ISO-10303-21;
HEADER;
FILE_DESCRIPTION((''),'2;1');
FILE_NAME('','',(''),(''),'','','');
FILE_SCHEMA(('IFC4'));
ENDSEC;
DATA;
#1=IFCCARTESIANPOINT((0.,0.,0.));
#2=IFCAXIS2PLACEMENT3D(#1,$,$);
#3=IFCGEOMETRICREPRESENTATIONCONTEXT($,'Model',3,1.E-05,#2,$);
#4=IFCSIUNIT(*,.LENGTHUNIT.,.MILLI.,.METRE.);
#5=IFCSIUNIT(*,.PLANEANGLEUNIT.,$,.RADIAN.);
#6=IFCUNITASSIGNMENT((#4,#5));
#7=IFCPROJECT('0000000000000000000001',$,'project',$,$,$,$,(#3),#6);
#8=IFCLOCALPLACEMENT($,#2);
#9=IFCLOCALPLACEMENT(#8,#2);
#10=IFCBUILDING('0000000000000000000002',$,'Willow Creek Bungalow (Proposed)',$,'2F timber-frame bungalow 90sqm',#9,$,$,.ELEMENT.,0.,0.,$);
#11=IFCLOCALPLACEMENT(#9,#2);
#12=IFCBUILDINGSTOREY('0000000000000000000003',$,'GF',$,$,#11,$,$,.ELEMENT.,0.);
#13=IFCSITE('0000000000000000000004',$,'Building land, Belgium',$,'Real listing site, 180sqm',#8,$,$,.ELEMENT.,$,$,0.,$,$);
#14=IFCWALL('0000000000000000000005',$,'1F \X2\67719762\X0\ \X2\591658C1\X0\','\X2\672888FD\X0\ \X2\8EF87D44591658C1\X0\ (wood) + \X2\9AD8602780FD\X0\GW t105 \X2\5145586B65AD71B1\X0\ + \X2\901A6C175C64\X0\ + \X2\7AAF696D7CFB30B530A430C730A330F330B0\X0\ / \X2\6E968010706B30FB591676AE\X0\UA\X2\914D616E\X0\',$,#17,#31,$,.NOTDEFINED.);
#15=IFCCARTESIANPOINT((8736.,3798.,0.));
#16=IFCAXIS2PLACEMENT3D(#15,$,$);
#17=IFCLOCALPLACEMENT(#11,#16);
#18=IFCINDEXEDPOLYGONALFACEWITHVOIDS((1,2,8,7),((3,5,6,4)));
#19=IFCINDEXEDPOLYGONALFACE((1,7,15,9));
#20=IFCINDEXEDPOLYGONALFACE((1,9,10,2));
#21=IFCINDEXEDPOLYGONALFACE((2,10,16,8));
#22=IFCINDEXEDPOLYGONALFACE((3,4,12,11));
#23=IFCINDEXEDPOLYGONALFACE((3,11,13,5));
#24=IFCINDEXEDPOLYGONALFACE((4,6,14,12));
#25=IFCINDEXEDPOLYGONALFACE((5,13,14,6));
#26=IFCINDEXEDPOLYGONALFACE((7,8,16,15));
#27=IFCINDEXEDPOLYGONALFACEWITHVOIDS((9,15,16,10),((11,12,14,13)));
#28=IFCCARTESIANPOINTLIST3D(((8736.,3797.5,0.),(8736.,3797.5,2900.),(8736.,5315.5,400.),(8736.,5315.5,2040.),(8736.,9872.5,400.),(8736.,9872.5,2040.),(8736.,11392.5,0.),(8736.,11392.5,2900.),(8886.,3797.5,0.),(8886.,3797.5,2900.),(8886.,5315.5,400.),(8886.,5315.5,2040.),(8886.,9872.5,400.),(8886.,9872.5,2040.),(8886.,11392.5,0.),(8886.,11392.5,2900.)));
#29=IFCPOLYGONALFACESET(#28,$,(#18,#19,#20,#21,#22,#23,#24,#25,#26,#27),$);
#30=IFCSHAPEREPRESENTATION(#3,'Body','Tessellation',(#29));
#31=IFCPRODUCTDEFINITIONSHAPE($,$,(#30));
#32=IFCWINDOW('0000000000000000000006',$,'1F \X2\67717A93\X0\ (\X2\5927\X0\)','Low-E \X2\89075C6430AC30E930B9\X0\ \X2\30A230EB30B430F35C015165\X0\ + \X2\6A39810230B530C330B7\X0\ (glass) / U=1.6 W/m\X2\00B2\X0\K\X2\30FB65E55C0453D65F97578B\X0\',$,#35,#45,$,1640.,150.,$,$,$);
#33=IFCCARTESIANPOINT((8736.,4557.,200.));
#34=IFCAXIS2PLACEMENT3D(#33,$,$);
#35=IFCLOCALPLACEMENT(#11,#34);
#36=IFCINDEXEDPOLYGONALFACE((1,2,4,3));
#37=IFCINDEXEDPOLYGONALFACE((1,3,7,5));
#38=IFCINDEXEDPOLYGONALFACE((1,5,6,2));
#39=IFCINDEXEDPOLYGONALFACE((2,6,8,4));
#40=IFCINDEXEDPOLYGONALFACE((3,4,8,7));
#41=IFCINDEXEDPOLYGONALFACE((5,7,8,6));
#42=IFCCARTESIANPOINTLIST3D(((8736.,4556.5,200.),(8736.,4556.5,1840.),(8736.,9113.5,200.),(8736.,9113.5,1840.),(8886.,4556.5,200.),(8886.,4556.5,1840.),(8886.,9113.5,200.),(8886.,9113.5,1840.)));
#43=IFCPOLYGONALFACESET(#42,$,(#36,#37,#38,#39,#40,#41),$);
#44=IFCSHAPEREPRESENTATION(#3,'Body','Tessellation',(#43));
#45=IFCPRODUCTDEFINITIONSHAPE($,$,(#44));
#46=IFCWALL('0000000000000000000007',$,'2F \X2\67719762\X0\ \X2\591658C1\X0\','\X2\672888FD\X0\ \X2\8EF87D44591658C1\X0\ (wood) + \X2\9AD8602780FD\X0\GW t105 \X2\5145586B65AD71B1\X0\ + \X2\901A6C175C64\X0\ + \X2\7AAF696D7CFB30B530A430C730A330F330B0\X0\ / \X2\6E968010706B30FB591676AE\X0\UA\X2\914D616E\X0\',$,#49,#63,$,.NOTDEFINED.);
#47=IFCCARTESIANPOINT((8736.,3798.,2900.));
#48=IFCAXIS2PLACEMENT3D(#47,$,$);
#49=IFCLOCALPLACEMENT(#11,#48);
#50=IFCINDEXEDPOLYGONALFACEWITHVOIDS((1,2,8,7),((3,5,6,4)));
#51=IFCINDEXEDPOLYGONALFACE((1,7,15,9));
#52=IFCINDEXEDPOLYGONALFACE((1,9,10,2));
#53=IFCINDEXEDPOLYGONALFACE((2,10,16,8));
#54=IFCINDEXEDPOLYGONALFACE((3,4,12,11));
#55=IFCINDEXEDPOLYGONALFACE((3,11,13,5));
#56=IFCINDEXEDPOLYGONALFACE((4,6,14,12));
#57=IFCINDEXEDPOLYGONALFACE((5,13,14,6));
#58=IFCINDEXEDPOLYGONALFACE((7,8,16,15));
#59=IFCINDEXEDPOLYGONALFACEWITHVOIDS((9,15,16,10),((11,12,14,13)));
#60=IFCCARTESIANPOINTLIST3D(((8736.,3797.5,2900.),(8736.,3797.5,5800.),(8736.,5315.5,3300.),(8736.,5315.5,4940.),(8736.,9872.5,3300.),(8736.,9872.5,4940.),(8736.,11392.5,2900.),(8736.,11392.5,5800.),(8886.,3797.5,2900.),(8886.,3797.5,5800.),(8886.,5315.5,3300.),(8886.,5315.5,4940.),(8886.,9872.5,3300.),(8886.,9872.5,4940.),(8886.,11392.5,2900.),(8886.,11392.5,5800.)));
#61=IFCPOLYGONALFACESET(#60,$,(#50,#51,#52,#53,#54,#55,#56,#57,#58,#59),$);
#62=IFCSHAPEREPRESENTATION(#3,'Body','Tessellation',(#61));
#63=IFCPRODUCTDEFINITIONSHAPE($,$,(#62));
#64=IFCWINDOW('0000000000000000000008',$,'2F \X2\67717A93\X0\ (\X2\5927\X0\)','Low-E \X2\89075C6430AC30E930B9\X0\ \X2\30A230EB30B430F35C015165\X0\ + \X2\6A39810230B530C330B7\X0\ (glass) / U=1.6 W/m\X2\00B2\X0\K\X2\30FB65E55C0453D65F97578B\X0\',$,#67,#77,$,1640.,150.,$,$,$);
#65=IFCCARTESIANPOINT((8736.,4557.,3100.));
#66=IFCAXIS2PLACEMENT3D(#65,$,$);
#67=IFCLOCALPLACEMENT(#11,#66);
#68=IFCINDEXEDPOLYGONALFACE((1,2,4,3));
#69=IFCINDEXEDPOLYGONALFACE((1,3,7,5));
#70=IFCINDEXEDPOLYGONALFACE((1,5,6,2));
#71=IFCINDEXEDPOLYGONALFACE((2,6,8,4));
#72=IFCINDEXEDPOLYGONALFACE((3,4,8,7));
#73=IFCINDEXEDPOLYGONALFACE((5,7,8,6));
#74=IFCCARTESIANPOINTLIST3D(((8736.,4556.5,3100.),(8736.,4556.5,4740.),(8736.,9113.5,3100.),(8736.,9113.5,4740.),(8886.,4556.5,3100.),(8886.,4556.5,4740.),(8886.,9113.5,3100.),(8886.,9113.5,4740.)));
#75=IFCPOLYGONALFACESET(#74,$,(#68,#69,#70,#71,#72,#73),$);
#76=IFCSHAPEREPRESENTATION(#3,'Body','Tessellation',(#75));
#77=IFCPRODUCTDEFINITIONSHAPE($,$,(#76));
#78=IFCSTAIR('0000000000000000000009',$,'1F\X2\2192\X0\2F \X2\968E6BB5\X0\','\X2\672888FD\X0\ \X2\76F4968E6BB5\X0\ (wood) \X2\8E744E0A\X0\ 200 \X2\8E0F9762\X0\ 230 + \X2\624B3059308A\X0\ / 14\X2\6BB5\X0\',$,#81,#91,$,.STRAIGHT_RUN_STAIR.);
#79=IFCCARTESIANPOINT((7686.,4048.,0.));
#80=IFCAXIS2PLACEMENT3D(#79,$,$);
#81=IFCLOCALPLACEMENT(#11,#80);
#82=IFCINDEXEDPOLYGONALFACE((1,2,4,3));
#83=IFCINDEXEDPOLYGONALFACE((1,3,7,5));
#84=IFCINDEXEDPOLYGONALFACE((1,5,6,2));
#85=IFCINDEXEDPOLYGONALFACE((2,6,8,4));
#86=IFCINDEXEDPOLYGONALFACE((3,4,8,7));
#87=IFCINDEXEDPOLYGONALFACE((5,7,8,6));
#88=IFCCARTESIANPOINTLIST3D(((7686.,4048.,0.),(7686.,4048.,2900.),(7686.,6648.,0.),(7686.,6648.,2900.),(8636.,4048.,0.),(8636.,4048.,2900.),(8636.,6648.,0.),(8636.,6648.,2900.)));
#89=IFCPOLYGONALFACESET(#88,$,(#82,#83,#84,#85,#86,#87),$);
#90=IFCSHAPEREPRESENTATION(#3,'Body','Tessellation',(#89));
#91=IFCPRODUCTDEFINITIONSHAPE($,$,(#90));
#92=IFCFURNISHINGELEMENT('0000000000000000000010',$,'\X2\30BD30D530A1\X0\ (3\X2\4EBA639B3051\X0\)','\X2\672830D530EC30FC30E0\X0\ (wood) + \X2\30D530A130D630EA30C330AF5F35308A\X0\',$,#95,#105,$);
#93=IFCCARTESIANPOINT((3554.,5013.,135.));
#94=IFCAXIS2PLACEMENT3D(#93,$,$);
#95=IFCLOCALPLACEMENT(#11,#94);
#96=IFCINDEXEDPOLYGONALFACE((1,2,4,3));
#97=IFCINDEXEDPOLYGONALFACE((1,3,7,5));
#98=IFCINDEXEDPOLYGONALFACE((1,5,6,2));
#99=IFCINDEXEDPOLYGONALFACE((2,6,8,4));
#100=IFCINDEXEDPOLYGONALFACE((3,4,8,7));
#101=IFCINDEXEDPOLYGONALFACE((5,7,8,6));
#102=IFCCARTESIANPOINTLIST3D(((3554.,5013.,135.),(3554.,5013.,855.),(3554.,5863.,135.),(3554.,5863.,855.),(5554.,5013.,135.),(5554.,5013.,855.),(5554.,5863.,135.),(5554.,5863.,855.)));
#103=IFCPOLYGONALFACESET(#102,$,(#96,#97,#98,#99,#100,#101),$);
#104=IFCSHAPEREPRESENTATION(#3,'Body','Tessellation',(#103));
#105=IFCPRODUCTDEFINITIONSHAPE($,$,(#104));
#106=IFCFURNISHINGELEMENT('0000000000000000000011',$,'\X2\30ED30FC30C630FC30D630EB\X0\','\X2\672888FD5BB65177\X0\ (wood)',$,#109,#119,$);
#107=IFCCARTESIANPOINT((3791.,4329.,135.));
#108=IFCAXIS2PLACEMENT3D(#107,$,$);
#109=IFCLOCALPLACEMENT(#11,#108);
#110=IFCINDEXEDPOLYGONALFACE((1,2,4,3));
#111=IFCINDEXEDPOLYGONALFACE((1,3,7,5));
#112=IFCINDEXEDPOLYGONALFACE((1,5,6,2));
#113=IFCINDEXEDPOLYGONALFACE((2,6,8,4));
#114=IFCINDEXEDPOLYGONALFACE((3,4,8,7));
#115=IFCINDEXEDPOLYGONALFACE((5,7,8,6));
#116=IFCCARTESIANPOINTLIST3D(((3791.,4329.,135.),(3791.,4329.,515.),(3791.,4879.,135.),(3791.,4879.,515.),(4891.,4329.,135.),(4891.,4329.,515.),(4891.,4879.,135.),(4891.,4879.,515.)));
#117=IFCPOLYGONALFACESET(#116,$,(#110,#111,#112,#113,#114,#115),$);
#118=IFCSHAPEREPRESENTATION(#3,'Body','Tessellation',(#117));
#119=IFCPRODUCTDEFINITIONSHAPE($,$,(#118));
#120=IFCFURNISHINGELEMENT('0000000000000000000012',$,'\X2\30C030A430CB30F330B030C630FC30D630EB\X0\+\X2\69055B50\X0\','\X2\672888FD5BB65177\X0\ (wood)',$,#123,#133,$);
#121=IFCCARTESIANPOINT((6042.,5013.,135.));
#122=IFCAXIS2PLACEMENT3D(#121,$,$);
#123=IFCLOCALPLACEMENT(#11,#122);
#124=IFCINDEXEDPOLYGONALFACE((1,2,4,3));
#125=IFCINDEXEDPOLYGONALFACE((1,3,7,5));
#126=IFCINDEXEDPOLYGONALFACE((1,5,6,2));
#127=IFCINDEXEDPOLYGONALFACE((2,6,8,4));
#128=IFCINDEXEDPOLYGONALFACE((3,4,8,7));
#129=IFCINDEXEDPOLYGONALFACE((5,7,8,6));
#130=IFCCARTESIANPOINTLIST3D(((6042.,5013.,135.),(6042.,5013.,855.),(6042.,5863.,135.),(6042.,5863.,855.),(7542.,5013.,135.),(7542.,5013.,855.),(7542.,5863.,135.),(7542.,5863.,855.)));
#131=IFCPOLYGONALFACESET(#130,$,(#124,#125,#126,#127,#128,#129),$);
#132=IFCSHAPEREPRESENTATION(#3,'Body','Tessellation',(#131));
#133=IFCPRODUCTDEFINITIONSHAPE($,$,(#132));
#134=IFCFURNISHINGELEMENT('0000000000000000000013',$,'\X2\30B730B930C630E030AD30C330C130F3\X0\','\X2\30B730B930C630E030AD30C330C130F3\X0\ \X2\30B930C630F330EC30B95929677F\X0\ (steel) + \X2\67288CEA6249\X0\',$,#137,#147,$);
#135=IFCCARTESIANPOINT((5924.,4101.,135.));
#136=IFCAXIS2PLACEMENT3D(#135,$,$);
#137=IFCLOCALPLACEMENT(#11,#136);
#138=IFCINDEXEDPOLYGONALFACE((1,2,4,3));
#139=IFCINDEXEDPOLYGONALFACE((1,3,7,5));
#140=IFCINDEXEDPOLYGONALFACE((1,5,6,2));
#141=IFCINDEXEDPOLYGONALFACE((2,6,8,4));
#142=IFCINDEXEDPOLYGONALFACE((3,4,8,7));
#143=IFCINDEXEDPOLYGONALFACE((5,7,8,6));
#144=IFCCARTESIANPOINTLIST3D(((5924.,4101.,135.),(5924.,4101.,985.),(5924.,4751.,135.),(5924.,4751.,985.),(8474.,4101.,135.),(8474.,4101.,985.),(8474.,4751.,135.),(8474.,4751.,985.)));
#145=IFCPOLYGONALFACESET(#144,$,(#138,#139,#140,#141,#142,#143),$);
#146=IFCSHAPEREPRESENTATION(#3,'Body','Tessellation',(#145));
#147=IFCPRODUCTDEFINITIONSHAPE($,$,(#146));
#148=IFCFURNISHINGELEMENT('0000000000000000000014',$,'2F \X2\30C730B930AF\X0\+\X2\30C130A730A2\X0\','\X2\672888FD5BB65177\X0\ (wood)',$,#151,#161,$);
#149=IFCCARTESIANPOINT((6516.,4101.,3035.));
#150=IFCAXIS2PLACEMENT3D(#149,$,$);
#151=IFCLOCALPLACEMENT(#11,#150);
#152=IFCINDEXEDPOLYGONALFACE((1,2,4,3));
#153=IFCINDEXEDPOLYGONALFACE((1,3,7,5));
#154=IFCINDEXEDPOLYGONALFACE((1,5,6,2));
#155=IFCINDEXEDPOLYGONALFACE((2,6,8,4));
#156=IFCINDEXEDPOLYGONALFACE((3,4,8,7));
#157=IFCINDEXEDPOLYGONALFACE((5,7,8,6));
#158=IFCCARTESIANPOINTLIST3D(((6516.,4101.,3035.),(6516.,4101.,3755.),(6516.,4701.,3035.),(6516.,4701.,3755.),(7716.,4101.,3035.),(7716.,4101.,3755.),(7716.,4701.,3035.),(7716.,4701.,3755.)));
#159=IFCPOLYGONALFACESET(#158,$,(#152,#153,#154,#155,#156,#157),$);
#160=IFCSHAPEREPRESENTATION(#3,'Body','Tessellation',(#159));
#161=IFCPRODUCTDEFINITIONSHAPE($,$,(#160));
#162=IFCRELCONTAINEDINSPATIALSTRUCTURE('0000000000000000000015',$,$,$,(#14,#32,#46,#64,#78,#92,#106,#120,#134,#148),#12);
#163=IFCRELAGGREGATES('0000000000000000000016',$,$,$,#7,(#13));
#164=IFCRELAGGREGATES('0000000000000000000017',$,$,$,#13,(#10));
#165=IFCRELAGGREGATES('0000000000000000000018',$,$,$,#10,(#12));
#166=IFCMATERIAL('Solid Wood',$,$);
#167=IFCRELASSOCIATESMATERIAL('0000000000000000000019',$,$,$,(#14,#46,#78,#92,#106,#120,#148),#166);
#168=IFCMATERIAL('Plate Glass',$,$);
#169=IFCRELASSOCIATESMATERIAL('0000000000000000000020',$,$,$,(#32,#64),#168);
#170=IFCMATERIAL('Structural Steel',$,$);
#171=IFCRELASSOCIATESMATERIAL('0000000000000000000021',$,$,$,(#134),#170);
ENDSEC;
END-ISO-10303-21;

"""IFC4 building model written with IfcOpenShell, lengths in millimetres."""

from ifc_helpers import new_model, si_unit, frame, frame_2d, origin, place, context, project, spatial, rectangle, extrude, material, element, fill, save


model = new_model("IFC4")

# Units and contexts
model_context = context("Model", 3, precision=1e-05, world=origin())
ifc_project = project(units=[si_unit("LENGTHUNIT", "METRE", prefix="MILLI"), si_unit("PLANEANGLEUNIT", "RADIAN")], contexts=[model_context])

# Site, building, storey
site_placement = place(None, origin())
site = spatial("IfcSite", under=ifc_project, at=site_placement, Name="Building land, Belgium", ObjectType="Real listing site, 180sqm", CompositionType="ELEMENT", RefElevation=0.0)
building_placement = place(site_placement, origin())
building = spatial("IfcBuilding", under=site, at=building_placement, Name="Willow Creek Bungalow (Proposed)", ObjectType="2F timber-frame bungalow 90sqm", CompositionType="ELEMENT", ElevationOfRefHeight=0.0, ElevationOfTerrain=0.0)
storey_placement = place(building_placement, origin())
storey = spatial("IfcBuildingStorey", under=building, at=storey_placement, Name="GF", CompositionType="ELEMENT", Elevation=0.0)

# Wall, opening, window
ifc_material_1 = material(Name="Solid Wood")
wall_1_placement = place(storey_placement, frame((8736.0, 3798.0, 0.0)))
wall_1 = element("IfcWall", 1, at=wall_1_placement, inside=storey, material=ifc_material_1, Name="1F 東面 外壁", Description="木製 軸組外壁 (wood) + 高性能GW t105 充填断熱 + 通気層 + 窯業系サイディング / 準耐火・外皮UA配慮", PredefinedType="NOTDEFINED", context=model_context, shape_type="SweptSolid", body=[
    extrude(rectangle(XDim=150.0, YDim=7595.0, at=frame_2d((75.0, 3797.0))), frame((8736.0, 3798.0, 0.0)), (0.0, 0.0, 1.0), 2900.0),
])
opening_1_placement = place(storey_placement, frame((8736.0, 4557.0, 200.0)))
opening_1 = element("IfcOpeningElement", 2, at=opening_1_placement, cuts=wall_1, PredefinedType="NOTDEFINED", context=model_context, shape_type="SweptSolid", body=[
    extrude(rectangle(XDim=150.0, YDim=4557.0, at=frame_2d((75.0, 2278.0))), frame((8736.0, 4557.0, 200.0)), (0.0, 0.0, 1.0), 1640.0),
])
ifc_material_2 = material(Name="Plate Glass")
window_1_placement = place(storey_placement, frame((8736.0, 4557.0, 200.0)))
window_1 = element("IfcWindow", 3, at=window_1_placement, inside=storey, material=ifc_material_2, Name="1F 東窓 (大)", Description="Low-E 複層ガラス アルゴン封入 + 樹脂サッシ (glass) / U=1.6 W/m²K・日射取得型", OverallHeight=1640.0, OverallWidth=150.0, context=model_context, shape_type="SweptSolid", body=[
    extrude(rectangle(XDim=150.0, YDim=4557.0, at=frame_2d((75.0, 2278.0))), frame((8736.0, 4557.0, 200.0)), (0.0, 0.0, 1.0), 1640.0),
])
fill(opening_1, window_1)

# Wall, opening, window
wall_2_placement = place(storey_placement, frame((8736.0, 3798.0, 2900.0)))
wall_2 = element("IfcWall", 4, at=wall_2_placement, inside=storey, material=ifc_material_1, Name="2F 東面 外壁", Description="木製 軸組外壁 (wood) + 高性能GW t105 充填断熱 + 通気層 + 窯業系サイディング / 準耐火・外皮UA配慮", PredefinedType="NOTDEFINED", context=model_context, shape_type="SweptSolid", body=[
    extrude(rectangle(XDim=150.0, YDim=7595.0, at=frame_2d((75.0, 3797.0))), frame((8736.0, 3798.0, 2900.0)), (0.0, 0.0, 1.0), 2900.0),
])
opening_2_placement = place(storey_placement, frame((8736.0, 4557.0, 3100.0)))
opening_2 = element("IfcOpeningElement", 5, at=opening_2_placement, cuts=wall_2, PredefinedType="NOTDEFINED", context=model_context, shape_type="SweptSolid", body=[
    extrude(rectangle(XDim=150.0, YDim=4557.0, at=frame_2d((75.0, 2278.0))), frame((8736.0, 4557.0, 3100.0)), (0.0, 0.0, 1.0), 1640.0),
])
window_2_placement = place(storey_placement, frame((8736.0, 4557.0, 3100.0)))
window_2 = element("IfcWindow", 6, at=window_2_placement, inside=storey, material=ifc_material_2, Name="2F 東窓 (大)", Description="Low-E 複層ガラス アルゴン封入 + 樹脂サッシ (glass) / U=1.6 W/m²K・日射取得型", OverallHeight=1640.0, OverallWidth=150.0, context=model_context, shape_type="SweptSolid", body=[
    extrude(rectangle(XDim=150.0, YDim=4557.0, at=frame_2d((75.0, 2278.0))), frame((8736.0, 4557.0, 3100.0)), (0.0, 0.0, 1.0), 1640.0),
])
fill(opening_2, window_2)

# Stair
stair_placement = place(storey_placement, frame((7686.0, 4048.0, 0.0)))
element("IfcStair", 7, at=stair_placement, inside=storey, material=ifc_material_1, Name="1F→2F 階段", Description="木製 直階段 (wood) 蹴上 200 踏面 230 + 手すり / 14段", PredefinedType="STRAIGHT_RUN_STAIR", context=model_context, shape_type="SweptSolid", body=[
    extrude(rectangle(XDim=950.0, YDim=2600.0, at=frame_2d((475.0, 1300.0))), frame((7686.0, 4048.0, 0.0)), (0.0, 0.0, 1.0), 2900.0),
])

# Furnishing elements
furnishing_1_placement = place(storey_placement, frame((3554.0, 5013.0, 135.0)))
element("IfcFurnishingElement", 8, at=furnishing_1_placement, inside=storey, material=ifc_material_1, Name="ソファ (3人掛け)", Description="木フレーム (wood) + ファブリック張り", context=model_context, shape_type="SweptSolid", body=[
    extrude(rectangle(XDim=2000.0, YDim=850.0, at=frame_2d((1000.0, 425.0))), frame((3554.0, 5013.0, 135.0)), (0.0, 0.0, 1.0), 720.0),
])
furnishing_2_placement = place(storey_placement, frame((3791.0, 4329.0, 135.0)))
element("IfcFurnishingElement", 9, at=furnishing_2_placement, inside=storey, material=ifc_material_1, Name="ローテーブル", Description="木製家具 (wood)", context=model_context, shape_type="SweptSolid", body=[
    extrude(rectangle(XDim=1100.0, YDim=550.0, at=frame_2d((550.0, 275.0))), frame((3791.0, 4329.0, 135.0)), (0.0, 0.0, 1.0), 380.0),
])
furnishing_3_placement = place(storey_placement, frame((6042.0, 5013.0, 135.0)))
element("IfcFurnishingElement", 10, at=furnishing_3_placement, inside=storey, material=ifc_material_1, Name="ダイニングテーブル+椅子", Description="木製家具 (wood)", context=model_context, shape_type="SweptSolid", body=[
    extrude(rectangle(XDim=1500.0, YDim=850.0, at=frame_2d((750.0, 425.0))), frame((6042.0, 5013.0, 135.0)), (0.0, 0.0, 1.0), 720.0),
])
ifc_material_3 = material(Name="Structural Steel")
furnishing_4_placement = place(storey_placement, frame((5924.0, 4101.0, 135.0)))
element("IfcFurnishingElement", 11, at=furnishing_4_placement, inside=storey, material=ifc_material_3, Name="システムキッチン", Description="システムキッチン ステンレス天板 (steel) + 木質扉", context=model_context, shape_type="SweptSolid", body=[
    extrude(rectangle(XDim=2550.0, YDim=650.0, at=frame_2d((1275.0, 325.0))), frame((5924.0, 4101.0, 135.0)), (0.0, 0.0, 1.0), 850.0),
])
furnishing_5_placement = place(storey_placement, frame((6516.0, 4101.0, 3035.0)))
element("IfcFurnishingElement", 12, at=furnishing_5_placement, inside=storey, material=ifc_material_1, Name="2F デスク+チェア", Description="木製家具 (wood)", context=model_context, shape_type="SweptSolid", body=[
    extrude(rectangle(XDim=1200.0, YDim=600.0, at=frame_2d((600.0, 300.0))), frame((6516.0, 4101.0, 3035.0)), (0.0, 0.0, 1.0), 720.0),
])

save(model, "model.ifc")
